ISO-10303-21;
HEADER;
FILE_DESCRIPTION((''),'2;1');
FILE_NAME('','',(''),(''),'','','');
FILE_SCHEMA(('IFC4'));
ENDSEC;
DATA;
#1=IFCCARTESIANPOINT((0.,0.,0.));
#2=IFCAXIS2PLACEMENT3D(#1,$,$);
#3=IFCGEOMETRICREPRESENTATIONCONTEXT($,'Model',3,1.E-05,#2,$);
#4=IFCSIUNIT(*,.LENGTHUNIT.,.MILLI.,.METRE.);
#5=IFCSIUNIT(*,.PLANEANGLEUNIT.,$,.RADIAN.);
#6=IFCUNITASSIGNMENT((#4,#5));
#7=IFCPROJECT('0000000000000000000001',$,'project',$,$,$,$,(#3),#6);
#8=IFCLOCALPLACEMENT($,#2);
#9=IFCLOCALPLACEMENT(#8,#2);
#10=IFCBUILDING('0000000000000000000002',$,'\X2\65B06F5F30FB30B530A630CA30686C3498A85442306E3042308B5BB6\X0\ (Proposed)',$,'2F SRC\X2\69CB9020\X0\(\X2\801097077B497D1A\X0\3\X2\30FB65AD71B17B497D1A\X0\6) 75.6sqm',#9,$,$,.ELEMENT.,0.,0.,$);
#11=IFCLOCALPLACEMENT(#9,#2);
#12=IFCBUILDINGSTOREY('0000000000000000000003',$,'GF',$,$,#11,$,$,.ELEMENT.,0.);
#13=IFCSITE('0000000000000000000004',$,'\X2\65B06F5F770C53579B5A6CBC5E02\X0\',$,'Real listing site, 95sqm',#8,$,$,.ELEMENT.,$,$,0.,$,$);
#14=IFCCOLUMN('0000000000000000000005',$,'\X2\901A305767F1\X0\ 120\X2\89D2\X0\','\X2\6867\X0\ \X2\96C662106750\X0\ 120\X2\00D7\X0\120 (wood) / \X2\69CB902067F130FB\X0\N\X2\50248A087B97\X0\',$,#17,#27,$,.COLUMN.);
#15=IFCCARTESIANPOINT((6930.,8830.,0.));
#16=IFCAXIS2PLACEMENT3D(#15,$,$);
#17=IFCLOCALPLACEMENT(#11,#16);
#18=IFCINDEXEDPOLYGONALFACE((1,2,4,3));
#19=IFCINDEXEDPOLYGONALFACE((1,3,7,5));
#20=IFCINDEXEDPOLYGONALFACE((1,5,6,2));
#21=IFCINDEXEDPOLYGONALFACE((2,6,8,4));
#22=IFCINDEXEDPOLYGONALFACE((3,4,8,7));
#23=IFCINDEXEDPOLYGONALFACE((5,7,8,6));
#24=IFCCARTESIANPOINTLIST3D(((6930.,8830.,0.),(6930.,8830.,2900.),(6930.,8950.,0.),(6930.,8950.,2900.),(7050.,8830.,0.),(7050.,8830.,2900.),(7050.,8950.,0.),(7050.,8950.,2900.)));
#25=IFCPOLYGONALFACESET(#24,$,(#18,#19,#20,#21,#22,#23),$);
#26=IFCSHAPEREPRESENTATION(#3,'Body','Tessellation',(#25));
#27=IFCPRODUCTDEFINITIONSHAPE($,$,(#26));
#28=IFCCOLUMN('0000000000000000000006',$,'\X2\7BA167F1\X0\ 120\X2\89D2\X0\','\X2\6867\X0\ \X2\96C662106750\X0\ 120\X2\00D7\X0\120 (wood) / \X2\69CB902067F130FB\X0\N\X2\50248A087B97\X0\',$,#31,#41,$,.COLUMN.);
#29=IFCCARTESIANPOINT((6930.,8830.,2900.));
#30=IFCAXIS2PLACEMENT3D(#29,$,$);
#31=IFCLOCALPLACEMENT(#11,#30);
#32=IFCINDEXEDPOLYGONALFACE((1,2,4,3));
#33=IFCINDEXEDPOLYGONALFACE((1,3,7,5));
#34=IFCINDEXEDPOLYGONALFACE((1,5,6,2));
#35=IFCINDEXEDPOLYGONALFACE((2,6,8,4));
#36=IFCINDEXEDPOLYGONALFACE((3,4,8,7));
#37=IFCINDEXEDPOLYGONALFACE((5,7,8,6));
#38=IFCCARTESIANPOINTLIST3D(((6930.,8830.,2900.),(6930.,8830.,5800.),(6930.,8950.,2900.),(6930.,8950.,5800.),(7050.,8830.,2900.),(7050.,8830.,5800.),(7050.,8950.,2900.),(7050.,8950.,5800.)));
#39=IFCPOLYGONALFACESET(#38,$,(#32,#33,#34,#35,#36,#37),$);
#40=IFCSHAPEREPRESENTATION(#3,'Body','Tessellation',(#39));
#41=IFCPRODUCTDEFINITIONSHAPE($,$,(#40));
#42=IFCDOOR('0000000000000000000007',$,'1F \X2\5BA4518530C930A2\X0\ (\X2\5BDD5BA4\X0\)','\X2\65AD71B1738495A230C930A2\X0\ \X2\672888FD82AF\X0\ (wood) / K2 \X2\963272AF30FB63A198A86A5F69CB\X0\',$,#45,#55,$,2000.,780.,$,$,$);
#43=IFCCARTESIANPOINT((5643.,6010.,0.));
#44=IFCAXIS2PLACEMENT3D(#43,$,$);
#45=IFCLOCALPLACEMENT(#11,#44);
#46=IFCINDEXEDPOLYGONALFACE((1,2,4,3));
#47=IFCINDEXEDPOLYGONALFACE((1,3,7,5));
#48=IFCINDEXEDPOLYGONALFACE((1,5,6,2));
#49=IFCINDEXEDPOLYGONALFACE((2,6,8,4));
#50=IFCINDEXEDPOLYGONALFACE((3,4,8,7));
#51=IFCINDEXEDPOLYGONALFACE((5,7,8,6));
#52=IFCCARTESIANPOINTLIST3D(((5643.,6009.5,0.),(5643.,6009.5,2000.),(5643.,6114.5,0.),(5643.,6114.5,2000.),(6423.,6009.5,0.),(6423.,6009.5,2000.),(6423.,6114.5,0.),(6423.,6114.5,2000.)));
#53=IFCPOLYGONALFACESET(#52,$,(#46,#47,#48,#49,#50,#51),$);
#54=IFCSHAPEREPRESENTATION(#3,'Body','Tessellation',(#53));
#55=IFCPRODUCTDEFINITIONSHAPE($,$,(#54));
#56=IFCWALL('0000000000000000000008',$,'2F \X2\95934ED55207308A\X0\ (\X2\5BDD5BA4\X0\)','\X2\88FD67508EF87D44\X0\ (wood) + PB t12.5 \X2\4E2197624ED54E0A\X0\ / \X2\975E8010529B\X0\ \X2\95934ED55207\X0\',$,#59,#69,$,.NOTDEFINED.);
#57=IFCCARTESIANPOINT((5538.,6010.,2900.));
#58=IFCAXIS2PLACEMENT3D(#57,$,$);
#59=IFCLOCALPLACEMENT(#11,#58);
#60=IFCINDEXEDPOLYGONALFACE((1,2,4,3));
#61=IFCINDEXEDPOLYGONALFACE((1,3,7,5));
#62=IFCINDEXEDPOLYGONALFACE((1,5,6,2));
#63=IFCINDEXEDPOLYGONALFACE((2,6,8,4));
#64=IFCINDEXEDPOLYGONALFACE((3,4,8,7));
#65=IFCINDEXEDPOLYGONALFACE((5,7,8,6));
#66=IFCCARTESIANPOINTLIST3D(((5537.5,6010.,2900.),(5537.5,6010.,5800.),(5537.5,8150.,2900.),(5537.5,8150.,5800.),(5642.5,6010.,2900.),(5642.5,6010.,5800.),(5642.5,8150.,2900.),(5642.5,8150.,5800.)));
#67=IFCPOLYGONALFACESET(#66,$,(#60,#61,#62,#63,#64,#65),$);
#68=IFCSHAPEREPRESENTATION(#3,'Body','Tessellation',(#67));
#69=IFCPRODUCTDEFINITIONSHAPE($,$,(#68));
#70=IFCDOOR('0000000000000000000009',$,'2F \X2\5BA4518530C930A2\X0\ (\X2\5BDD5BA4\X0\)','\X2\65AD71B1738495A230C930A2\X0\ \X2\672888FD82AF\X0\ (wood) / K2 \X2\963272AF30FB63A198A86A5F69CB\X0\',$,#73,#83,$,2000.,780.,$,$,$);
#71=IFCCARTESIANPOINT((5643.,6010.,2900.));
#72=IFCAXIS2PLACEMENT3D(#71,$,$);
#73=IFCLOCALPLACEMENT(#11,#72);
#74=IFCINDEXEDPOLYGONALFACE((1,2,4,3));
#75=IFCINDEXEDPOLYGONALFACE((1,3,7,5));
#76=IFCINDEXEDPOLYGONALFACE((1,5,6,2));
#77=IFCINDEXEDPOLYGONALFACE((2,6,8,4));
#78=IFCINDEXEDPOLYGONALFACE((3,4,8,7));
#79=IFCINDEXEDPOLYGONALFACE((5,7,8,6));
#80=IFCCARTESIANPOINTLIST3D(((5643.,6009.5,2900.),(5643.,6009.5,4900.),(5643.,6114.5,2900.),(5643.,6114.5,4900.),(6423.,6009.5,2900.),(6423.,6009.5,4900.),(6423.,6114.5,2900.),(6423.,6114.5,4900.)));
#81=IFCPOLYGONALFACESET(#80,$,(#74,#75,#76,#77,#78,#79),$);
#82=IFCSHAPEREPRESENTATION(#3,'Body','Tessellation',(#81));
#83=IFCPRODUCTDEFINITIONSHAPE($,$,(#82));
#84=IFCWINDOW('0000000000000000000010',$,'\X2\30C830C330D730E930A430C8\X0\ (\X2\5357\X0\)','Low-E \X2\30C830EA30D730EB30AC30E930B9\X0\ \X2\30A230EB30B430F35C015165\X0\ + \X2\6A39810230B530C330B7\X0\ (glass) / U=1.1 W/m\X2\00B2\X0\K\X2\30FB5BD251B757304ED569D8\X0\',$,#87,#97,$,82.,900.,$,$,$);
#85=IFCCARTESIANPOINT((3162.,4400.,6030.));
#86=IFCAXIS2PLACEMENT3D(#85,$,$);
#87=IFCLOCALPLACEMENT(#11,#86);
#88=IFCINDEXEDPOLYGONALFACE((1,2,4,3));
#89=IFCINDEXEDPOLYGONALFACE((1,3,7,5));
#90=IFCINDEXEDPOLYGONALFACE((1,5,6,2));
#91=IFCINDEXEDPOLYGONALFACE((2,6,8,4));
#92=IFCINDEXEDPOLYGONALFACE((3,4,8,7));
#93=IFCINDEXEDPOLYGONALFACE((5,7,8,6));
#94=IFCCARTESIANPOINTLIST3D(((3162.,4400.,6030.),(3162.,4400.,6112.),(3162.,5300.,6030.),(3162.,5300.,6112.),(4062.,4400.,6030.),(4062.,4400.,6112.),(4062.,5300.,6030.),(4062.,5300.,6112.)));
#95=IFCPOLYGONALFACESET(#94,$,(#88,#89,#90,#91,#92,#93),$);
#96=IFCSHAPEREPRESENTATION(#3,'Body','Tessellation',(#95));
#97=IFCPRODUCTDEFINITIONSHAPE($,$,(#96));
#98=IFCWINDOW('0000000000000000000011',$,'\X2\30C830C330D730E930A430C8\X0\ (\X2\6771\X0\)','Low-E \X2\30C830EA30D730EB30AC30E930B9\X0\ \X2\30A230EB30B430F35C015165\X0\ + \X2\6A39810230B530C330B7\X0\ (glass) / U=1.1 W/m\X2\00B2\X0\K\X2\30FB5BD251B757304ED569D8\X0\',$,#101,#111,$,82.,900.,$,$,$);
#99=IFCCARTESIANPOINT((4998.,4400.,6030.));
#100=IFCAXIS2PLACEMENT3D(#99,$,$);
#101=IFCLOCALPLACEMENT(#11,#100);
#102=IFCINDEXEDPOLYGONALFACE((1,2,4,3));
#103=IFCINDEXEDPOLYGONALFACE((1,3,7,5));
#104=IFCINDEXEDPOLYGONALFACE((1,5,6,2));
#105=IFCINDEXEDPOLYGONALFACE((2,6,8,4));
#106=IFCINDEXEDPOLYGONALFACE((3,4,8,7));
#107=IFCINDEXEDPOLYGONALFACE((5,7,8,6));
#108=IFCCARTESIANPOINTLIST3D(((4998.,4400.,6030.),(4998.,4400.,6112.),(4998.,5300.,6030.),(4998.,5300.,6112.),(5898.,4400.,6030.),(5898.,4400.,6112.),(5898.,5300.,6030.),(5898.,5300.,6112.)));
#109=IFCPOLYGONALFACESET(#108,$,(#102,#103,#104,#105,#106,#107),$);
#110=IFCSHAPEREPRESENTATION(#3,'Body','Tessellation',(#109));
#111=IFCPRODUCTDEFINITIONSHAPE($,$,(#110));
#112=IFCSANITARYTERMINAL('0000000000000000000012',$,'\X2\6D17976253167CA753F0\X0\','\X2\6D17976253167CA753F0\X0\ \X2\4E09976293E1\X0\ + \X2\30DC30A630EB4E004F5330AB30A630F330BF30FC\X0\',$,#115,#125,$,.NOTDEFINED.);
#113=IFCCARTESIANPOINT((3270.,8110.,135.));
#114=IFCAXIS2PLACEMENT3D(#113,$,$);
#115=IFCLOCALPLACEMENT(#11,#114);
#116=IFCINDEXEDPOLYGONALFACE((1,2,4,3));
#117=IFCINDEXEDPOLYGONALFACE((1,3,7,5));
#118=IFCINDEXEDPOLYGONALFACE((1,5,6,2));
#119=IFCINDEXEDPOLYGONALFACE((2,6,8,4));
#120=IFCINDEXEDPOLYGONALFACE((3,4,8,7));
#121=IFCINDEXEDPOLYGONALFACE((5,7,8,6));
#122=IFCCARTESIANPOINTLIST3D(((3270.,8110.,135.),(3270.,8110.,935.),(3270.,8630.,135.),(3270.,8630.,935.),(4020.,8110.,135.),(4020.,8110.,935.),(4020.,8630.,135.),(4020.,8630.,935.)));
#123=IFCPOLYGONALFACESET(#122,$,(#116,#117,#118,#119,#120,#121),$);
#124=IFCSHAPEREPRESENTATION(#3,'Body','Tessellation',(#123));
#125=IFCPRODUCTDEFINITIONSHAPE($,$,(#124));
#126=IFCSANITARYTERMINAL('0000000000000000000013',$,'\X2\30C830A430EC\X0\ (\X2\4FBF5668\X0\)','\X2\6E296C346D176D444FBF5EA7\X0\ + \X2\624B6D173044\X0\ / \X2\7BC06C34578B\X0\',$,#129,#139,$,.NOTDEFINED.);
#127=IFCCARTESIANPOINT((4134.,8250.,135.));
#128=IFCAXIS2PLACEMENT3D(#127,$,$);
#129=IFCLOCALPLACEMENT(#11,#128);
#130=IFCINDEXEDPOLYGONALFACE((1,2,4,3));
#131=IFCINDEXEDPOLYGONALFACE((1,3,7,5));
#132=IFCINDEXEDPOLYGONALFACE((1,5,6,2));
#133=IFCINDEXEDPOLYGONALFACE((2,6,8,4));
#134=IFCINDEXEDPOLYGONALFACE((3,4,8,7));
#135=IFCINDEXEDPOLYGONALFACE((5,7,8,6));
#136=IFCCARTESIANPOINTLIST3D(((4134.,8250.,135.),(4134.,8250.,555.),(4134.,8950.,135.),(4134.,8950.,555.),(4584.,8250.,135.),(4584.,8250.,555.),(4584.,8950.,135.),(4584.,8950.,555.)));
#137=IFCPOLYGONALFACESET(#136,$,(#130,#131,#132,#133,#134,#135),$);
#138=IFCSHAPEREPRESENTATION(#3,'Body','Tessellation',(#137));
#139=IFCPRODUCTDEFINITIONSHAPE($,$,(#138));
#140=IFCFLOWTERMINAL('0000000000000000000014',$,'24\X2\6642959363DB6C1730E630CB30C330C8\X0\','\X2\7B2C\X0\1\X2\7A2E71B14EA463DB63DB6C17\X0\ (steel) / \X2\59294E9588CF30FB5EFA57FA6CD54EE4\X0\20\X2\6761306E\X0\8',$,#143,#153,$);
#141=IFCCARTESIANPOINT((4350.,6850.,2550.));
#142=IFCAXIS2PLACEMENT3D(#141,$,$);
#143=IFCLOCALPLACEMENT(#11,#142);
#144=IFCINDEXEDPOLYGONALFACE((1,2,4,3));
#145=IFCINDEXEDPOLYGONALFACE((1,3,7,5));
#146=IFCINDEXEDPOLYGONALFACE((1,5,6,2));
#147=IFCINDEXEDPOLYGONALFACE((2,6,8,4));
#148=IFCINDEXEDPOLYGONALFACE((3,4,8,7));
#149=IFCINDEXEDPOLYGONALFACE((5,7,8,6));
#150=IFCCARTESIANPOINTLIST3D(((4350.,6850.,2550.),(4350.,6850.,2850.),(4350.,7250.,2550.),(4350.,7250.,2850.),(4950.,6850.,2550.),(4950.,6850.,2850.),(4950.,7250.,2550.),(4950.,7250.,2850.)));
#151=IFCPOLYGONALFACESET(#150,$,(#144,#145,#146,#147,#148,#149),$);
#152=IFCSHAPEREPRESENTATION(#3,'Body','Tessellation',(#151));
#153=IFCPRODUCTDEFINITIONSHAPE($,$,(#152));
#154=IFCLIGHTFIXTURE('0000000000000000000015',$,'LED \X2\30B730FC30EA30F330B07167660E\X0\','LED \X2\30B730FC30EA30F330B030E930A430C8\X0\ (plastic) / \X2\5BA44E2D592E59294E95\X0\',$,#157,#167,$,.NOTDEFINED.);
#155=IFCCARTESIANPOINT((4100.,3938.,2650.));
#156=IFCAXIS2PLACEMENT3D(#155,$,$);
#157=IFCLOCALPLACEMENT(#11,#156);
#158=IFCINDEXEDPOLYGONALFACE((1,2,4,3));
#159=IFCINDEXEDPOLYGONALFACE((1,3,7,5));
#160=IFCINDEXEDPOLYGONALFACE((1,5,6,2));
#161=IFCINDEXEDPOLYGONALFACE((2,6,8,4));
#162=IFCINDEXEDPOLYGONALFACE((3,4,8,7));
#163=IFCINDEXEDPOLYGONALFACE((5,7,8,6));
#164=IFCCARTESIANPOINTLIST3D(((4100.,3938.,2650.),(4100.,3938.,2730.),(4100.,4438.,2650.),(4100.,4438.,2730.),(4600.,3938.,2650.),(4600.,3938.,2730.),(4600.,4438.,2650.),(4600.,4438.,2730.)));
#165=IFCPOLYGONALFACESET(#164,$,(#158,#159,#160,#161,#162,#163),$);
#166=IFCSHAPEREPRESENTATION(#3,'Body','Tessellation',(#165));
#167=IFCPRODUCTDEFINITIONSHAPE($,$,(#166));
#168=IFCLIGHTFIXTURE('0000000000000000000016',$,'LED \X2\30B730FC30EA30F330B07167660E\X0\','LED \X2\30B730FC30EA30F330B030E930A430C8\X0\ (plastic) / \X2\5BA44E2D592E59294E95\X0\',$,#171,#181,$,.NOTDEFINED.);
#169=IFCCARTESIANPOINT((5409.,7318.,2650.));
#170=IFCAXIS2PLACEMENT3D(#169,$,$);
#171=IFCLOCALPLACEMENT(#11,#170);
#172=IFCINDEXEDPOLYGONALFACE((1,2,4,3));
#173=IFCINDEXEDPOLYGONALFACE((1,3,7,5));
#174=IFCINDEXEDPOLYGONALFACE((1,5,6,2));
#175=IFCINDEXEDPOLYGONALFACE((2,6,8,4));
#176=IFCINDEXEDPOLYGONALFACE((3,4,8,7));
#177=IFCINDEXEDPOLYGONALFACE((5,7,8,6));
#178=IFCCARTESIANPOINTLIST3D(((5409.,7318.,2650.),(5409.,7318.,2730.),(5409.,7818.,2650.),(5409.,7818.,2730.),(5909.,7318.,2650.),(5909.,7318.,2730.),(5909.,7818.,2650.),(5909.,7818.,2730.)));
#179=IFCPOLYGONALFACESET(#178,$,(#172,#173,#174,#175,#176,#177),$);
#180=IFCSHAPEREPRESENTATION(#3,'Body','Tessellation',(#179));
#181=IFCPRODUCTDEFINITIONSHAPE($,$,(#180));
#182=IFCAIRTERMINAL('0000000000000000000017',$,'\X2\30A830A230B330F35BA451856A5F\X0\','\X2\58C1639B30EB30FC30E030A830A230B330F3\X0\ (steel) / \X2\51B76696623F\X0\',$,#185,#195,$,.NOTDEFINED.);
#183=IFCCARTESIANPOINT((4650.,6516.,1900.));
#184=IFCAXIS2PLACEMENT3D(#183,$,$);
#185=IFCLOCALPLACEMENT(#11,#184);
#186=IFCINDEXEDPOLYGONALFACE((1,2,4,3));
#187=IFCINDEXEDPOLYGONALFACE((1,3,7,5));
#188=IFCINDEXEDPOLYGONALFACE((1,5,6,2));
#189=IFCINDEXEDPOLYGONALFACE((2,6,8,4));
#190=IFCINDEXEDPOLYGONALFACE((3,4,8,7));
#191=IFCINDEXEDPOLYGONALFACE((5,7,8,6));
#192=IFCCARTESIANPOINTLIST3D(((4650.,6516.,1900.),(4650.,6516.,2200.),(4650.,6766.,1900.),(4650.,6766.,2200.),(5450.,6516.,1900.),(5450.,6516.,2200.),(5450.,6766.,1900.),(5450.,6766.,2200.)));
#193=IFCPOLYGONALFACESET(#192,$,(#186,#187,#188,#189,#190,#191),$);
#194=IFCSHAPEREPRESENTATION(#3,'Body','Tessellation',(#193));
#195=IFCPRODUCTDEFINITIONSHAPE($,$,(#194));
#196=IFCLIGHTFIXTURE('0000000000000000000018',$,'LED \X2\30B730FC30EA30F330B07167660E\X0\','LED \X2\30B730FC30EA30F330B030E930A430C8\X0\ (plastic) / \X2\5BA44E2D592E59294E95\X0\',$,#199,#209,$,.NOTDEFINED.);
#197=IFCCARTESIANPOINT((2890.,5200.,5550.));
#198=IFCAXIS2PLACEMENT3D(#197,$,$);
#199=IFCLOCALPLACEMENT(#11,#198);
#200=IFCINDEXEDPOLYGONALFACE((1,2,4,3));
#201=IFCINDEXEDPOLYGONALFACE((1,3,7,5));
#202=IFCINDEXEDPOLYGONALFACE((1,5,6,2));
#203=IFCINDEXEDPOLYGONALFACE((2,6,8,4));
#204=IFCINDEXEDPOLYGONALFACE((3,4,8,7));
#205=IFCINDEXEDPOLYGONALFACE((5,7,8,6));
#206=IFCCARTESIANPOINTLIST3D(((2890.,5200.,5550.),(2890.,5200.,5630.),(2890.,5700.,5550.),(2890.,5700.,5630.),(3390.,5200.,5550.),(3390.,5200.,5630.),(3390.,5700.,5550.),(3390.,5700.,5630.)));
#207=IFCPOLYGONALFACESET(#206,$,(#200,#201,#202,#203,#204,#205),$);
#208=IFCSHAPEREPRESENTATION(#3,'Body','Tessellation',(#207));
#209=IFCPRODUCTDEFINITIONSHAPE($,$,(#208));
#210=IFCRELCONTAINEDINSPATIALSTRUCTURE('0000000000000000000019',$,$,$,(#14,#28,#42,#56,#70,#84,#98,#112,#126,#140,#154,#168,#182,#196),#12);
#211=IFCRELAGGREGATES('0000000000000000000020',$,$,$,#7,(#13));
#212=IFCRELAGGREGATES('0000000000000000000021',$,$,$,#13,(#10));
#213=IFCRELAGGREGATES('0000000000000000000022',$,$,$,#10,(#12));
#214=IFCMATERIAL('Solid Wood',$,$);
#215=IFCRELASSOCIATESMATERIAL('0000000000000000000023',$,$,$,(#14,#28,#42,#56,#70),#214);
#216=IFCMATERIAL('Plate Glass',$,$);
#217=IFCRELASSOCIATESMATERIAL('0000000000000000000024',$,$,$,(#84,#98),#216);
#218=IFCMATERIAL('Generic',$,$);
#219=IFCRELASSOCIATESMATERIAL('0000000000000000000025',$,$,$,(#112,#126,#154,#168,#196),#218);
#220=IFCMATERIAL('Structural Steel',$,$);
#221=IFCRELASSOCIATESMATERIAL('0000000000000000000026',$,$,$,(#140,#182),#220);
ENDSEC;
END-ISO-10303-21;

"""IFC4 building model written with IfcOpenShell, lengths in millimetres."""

from ifc_helpers import new_model, si_unit, frame, frame_2d, origin, place, context, project, spatial, rectangle, extrude, material, element, save


model = new_model("IFC4")

# Units and contexts
model_context = context("Model", 3, precision=1e-05, world=origin())
ifc_project = project(units=[si_unit("LENGTHUNIT", "METRE", prefix="MILLI"), si_unit("PLANEANGLEUNIT", "RADIAN")], contexts=[model_context])

# Site, building, storey
site_placement = place(None, origin())
site = spatial("IfcSite", under=ifc_project, at=site_placement, Name="新潟県南魚沼市", ObjectType="Real listing site, 95sqm", CompositionType="ELEMENT", RefElevation=0.0)
building_placement = place(site_placement, origin())
building = spatial("IfcBuilding", under=site, at=building_placement, Name="新潟・サウナと水風呂のある家 (Proposed)", ObjectType="2F SRC構造(耐震等級3・断熱等級6) 75.6sqm", CompositionType="ELEMENT", ElevationOfRefHeight=0.0, ElevationOfTerrain=0.0)
storey_placement = place(building_placement, origin())
storey = spatial("IfcBuildingStorey", under=building, at=storey_placement, Name="GF", CompositionType="ELEMENT", Elevation=0.0)

# Columns
ifc_material_1 = material(Name="Solid Wood")
column_1_placement = place(storey_placement, frame((6930.0, 8830.0, 0.0)))
element("IfcColumn", 1, at=column_1_placement, inside=storey, material=ifc_material_1, Name="通し柱 120角", Description="桧 集成材 120×120 (wood) / 構造柱・N値計算", PredefinedType="COLUMN", context=model_context, shape_type="SweptSolid", body=[
    extrude(rectangle(XDim=120.0, YDim=120.0, at=frame_2d((60.0, 60.0))), frame((6930.0, 8830.0, 0.0)), (0.0, 0.0, 1.0), 2900.0),
])
column_2_placement = place(storey_placement, frame((6930.0, 8830.0, 2900.0)))
element("IfcColumn", 2, at=column_2_placement, inside=storey, material=ifc_material_1, Name="管柱 120角", Description="桧 集成材 120×120 (wood) / 構造柱・N値計算", PredefinedType="COLUMN", context=model_context, shape_type="SweptSolid", body=[
    extrude(rectangle(XDim=120.0, YDim=120.0, at=frame_2d((60.0, 60.0))), frame((6930.0, 8830.0, 2900.0)), (0.0, 0.0, 1.0), 2900.0),
])

# Door
door_1_placement = place(storey_placement, frame((5643.0, 6010.0, 0.0)))
element("IfcDoor", 3, at=door_1_placement, inside=storey, material=ifc_material_1, Name="1F 室内ドア (寝室)", Description="断熱玄関ドア 木製芯 (wood) / K2 防犯・採風機構", OverallHeight=2000.0, OverallWidth=780.0, context=model_context, shape_type="SweptSolid", body=[
    extrude(rectangle(XDim=780.0, YDim=105.0, at=frame_2d((390.0, 52.0))), frame((5643.0, 6010.0, 0.0)), (0.0, 0.0, 1.0), 2000.0),
])

# Wall
wall_1_placement = place(storey_placement, frame((5538.0, 6010.0, 2900.0)))
element("IfcWall", 4, at=wall_1_placement, inside=storey, material=ifc_material_1, Name="2F 間仕切り (寝室)", Description="製材軸組 (wood) + PB t12.5 両面仕上 / 非耐力 間仕切", PredefinedType="NOTDEFINED", context=model_context, shape_type="SweptSolid", body=[
    extrude(rectangle(XDim=105.0, YDim=2140.0, at=frame_2d((52.0, 1070.0))), frame((5538.0, 6010.0, 2900.0)), (0.0, 0.0, 1.0), 2900.0),
])

# Door
door_2_placement = place(storey_placement, frame((5643.0, 6010.0, 2900.0)))
element("IfcDoor", 5, at=door_2_placement, inside=storey, material=ifc_material_1, Name="2F 室内ドア (寝室)", Description="断熱玄関ドア 木製芯 (wood) / K2 防犯・採風機構", OverallHeight=2000.0, OverallWidth=780.0, context=model_context, shape_type="SweptSolid", body=[
    extrude(rectangle(XDim=780.0, YDim=105.0, at=frame_2d((390.0, 52.0))), frame((5643.0, 6010.0, 2900.0)), (0.0, 0.0, 1.0), 2000.0),
])

# Windows
ifc_material_2 = material(Name="Plate Glass")
window_1_placement = place(storey_placement, frame((3162.0, 4400.0, 6030.0)))
element("IfcWindow", 6, at=window_1_placement, inside=storey, material=ifc_material_2, Name="トップライト (南)", Description="Low-E トリプルガラス アルゴン封入 + 樹脂サッシ (glass) / U=1.1 W/m²K・寒冷地仕様", OverallHeight=82.0, OverallWidth=900.0, context=model_context, shape_type="SweptSolid", body=[
    extrude(rectangle(XDim=900.0, YDim=900.0, at=frame_2d((450.0, 450.0))), frame((3162.0, 4400.0, 6030.0)), (0.0, 0.0, 1.0), 82.0),
])
window_2_placement = place(storey_placement, frame((4998.0, 4400.0, 6030.0)))
element("IfcWindow", 7, at=window_2_placement, inside=storey, material=ifc_material_2, Name="トップライト (東)", Description="Low-E トリプルガラス アルゴン封入 + 樹脂サッシ (glass) / U=1.1 W/m²K・寒冷地仕様", OverallHeight=82.0, OverallWidth=900.0, context=model_context, shape_type="SweptSolid", body=[
    extrude(rectangle(XDim=900.0, YDim=900.0, at=frame_2d((450.0, 450.0))), frame((4998.0, 4400.0, 6030.0)), (0.0, 0.0, 1.0), 82.0),
])

# Sanitary terminals
ifc_material_3 = material(Name="Generic")
sanitary_terminal_1_placement = place(storey_placement, frame((3270.0, 8110.0, 135.0)))
element("IfcSanitaryTerminal", 8, at=sanitary_terminal_1_placement, inside=storey, material=ifc_material_3, Name="洗面化粧台", Description="洗面化粧台 三面鏡 + ボウル一体カウンター", PredefinedType="NOTDEFINED", context=model_context, shape_type="SweptSolid", body=[
    extrude(rectangle(XDim=750.0, YDim=520.0, at=frame_2d((375.0, 260.0))), frame((3270.0, 8110.0, 135.0)), (0.0, 0.0, 1.0), 800.0),
])
sanitary_terminal_2_placement = place(storey_placement, frame((4134.0, 8250.0, 135.0)))
element("IfcSanitaryTerminal", 9, at=sanitary_terminal_2_placement, inside=storey, material=ifc_material_3, Name="トイレ (便器)", Description="温水洗浄便座 + 手洗い / 節水型", PredefinedType="NOTDEFINED", context=model_context, shape_type="SweptSolid", body=[
    extrude(rectangle(XDim=450.0, YDim=700.0, at=frame_2d((225.0, 350.0))), frame((4134.0, 8250.0, 135.0)), (0.0, 0.0, 1.0), 420.0),
])

# Flow terminal
ifc_material_4 = material(Name="Structural Steel")
flow_terminal_placement = place(storey_placement, frame((4350.0, 6850.0, 2550.0)))
element("IfcFlowTerminal", 10, at=flow_terminal_placement, inside=storey, material=ifc_material_4, Name="24時間換気ユニット", Description="第1種熱交換換気 (steel) / 天井裏・建基法令20条の8", context=model_context, shape_type="SweptSolid", body=[
    extrude(rectangle(XDim=600.0, YDim=400.0, at=frame_2d((300.0, 200.0))), frame((4350.0, 6850.0, 2550.0)), (0.0, 0.0, 1.0), 300.0),
])

# Light fixtures
light_fixture_1_placement = place(storey_placement, frame((4100.0, 3938.0, 2650.0)))
element("IfcLightFixture", 11, at=light_fixture_1_placement, inside=storey, material=ifc_material_3, Name="LED シーリング照明", Description="LED シーリングライト (plastic) / 室中央天井", PredefinedType="NOTDEFINED", context=model_context, shape_type="SweptSolid", body=[
    extrude(rectangle(XDim=500.0, YDim=500.0, at=frame_2d((250.0, 250.0))), frame((4100.0, 3938.0, 2650.0)), (0.0, 0.0, 1.0), 80.0),
])
light_fixture_2_placement = place(storey_placement, frame((5409.0, 7318.0, 2650.0)))
element("IfcLightFixture", 12, at=light_fixture_2_placement, inside=storey, material=ifc_material_3, Name="LED シーリング照明", Description="LED シーリングライト (plastic) / 室中央天井", PredefinedType="NOTDEFINED", context=model_context, shape_type="SweptSolid", body=[
    extrude(rectangle(XDim=500.0, YDim=500.0, at=frame_2d((250.0, 250.0))), frame((5409.0, 7318.0, 2650.0)), (0.0, 0.0, 1.0), 80.0),
])

# Air terminal
air_terminal_placement = place(storey_placement, frame((4650.0, 6516.0, 1900.0)))
element("IfcAirTerminal", 13, at=air_terminal_placement, inside=storey, material=ifc_material_4, Name="エアコン室内機", Description="壁掛ルームエアコン (steel) / 冷暖房", PredefinedType="NOTDEFINED", context=model_context, shape_type="SweptSolid", body=[
    extrude(rectangle(XDim=800.0, YDim=250.0, at=frame_2d((400.0, 125.0))), frame((4650.0, 6516.0, 1900.0)), (0.0, 0.0, 1.0), 300.0),
])

# Light fixture
light_fixture_3_placement = place(storey_placement, frame((2890.0, 5200.0, 5550.0)))
element("IfcLightFixture", 14, at=light_fixture_3_placement, inside=storey, material=ifc_material_3, Name="LED シーリング照明", Description="LED シーリングライト (plastic) / 室中央天井", PredefinedType="NOTDEFINED", context=model_context, shape_type="SweptSolid", body=[
    extrude(rectangle(XDim=500.0, YDim=500.0, at=frame_2d((250.0, 250.0))), frame((2890.0, 5200.0, 5550.0)), (0.0, 0.0, 1.0), 80.0),
])

save(model, "model.ifc")
